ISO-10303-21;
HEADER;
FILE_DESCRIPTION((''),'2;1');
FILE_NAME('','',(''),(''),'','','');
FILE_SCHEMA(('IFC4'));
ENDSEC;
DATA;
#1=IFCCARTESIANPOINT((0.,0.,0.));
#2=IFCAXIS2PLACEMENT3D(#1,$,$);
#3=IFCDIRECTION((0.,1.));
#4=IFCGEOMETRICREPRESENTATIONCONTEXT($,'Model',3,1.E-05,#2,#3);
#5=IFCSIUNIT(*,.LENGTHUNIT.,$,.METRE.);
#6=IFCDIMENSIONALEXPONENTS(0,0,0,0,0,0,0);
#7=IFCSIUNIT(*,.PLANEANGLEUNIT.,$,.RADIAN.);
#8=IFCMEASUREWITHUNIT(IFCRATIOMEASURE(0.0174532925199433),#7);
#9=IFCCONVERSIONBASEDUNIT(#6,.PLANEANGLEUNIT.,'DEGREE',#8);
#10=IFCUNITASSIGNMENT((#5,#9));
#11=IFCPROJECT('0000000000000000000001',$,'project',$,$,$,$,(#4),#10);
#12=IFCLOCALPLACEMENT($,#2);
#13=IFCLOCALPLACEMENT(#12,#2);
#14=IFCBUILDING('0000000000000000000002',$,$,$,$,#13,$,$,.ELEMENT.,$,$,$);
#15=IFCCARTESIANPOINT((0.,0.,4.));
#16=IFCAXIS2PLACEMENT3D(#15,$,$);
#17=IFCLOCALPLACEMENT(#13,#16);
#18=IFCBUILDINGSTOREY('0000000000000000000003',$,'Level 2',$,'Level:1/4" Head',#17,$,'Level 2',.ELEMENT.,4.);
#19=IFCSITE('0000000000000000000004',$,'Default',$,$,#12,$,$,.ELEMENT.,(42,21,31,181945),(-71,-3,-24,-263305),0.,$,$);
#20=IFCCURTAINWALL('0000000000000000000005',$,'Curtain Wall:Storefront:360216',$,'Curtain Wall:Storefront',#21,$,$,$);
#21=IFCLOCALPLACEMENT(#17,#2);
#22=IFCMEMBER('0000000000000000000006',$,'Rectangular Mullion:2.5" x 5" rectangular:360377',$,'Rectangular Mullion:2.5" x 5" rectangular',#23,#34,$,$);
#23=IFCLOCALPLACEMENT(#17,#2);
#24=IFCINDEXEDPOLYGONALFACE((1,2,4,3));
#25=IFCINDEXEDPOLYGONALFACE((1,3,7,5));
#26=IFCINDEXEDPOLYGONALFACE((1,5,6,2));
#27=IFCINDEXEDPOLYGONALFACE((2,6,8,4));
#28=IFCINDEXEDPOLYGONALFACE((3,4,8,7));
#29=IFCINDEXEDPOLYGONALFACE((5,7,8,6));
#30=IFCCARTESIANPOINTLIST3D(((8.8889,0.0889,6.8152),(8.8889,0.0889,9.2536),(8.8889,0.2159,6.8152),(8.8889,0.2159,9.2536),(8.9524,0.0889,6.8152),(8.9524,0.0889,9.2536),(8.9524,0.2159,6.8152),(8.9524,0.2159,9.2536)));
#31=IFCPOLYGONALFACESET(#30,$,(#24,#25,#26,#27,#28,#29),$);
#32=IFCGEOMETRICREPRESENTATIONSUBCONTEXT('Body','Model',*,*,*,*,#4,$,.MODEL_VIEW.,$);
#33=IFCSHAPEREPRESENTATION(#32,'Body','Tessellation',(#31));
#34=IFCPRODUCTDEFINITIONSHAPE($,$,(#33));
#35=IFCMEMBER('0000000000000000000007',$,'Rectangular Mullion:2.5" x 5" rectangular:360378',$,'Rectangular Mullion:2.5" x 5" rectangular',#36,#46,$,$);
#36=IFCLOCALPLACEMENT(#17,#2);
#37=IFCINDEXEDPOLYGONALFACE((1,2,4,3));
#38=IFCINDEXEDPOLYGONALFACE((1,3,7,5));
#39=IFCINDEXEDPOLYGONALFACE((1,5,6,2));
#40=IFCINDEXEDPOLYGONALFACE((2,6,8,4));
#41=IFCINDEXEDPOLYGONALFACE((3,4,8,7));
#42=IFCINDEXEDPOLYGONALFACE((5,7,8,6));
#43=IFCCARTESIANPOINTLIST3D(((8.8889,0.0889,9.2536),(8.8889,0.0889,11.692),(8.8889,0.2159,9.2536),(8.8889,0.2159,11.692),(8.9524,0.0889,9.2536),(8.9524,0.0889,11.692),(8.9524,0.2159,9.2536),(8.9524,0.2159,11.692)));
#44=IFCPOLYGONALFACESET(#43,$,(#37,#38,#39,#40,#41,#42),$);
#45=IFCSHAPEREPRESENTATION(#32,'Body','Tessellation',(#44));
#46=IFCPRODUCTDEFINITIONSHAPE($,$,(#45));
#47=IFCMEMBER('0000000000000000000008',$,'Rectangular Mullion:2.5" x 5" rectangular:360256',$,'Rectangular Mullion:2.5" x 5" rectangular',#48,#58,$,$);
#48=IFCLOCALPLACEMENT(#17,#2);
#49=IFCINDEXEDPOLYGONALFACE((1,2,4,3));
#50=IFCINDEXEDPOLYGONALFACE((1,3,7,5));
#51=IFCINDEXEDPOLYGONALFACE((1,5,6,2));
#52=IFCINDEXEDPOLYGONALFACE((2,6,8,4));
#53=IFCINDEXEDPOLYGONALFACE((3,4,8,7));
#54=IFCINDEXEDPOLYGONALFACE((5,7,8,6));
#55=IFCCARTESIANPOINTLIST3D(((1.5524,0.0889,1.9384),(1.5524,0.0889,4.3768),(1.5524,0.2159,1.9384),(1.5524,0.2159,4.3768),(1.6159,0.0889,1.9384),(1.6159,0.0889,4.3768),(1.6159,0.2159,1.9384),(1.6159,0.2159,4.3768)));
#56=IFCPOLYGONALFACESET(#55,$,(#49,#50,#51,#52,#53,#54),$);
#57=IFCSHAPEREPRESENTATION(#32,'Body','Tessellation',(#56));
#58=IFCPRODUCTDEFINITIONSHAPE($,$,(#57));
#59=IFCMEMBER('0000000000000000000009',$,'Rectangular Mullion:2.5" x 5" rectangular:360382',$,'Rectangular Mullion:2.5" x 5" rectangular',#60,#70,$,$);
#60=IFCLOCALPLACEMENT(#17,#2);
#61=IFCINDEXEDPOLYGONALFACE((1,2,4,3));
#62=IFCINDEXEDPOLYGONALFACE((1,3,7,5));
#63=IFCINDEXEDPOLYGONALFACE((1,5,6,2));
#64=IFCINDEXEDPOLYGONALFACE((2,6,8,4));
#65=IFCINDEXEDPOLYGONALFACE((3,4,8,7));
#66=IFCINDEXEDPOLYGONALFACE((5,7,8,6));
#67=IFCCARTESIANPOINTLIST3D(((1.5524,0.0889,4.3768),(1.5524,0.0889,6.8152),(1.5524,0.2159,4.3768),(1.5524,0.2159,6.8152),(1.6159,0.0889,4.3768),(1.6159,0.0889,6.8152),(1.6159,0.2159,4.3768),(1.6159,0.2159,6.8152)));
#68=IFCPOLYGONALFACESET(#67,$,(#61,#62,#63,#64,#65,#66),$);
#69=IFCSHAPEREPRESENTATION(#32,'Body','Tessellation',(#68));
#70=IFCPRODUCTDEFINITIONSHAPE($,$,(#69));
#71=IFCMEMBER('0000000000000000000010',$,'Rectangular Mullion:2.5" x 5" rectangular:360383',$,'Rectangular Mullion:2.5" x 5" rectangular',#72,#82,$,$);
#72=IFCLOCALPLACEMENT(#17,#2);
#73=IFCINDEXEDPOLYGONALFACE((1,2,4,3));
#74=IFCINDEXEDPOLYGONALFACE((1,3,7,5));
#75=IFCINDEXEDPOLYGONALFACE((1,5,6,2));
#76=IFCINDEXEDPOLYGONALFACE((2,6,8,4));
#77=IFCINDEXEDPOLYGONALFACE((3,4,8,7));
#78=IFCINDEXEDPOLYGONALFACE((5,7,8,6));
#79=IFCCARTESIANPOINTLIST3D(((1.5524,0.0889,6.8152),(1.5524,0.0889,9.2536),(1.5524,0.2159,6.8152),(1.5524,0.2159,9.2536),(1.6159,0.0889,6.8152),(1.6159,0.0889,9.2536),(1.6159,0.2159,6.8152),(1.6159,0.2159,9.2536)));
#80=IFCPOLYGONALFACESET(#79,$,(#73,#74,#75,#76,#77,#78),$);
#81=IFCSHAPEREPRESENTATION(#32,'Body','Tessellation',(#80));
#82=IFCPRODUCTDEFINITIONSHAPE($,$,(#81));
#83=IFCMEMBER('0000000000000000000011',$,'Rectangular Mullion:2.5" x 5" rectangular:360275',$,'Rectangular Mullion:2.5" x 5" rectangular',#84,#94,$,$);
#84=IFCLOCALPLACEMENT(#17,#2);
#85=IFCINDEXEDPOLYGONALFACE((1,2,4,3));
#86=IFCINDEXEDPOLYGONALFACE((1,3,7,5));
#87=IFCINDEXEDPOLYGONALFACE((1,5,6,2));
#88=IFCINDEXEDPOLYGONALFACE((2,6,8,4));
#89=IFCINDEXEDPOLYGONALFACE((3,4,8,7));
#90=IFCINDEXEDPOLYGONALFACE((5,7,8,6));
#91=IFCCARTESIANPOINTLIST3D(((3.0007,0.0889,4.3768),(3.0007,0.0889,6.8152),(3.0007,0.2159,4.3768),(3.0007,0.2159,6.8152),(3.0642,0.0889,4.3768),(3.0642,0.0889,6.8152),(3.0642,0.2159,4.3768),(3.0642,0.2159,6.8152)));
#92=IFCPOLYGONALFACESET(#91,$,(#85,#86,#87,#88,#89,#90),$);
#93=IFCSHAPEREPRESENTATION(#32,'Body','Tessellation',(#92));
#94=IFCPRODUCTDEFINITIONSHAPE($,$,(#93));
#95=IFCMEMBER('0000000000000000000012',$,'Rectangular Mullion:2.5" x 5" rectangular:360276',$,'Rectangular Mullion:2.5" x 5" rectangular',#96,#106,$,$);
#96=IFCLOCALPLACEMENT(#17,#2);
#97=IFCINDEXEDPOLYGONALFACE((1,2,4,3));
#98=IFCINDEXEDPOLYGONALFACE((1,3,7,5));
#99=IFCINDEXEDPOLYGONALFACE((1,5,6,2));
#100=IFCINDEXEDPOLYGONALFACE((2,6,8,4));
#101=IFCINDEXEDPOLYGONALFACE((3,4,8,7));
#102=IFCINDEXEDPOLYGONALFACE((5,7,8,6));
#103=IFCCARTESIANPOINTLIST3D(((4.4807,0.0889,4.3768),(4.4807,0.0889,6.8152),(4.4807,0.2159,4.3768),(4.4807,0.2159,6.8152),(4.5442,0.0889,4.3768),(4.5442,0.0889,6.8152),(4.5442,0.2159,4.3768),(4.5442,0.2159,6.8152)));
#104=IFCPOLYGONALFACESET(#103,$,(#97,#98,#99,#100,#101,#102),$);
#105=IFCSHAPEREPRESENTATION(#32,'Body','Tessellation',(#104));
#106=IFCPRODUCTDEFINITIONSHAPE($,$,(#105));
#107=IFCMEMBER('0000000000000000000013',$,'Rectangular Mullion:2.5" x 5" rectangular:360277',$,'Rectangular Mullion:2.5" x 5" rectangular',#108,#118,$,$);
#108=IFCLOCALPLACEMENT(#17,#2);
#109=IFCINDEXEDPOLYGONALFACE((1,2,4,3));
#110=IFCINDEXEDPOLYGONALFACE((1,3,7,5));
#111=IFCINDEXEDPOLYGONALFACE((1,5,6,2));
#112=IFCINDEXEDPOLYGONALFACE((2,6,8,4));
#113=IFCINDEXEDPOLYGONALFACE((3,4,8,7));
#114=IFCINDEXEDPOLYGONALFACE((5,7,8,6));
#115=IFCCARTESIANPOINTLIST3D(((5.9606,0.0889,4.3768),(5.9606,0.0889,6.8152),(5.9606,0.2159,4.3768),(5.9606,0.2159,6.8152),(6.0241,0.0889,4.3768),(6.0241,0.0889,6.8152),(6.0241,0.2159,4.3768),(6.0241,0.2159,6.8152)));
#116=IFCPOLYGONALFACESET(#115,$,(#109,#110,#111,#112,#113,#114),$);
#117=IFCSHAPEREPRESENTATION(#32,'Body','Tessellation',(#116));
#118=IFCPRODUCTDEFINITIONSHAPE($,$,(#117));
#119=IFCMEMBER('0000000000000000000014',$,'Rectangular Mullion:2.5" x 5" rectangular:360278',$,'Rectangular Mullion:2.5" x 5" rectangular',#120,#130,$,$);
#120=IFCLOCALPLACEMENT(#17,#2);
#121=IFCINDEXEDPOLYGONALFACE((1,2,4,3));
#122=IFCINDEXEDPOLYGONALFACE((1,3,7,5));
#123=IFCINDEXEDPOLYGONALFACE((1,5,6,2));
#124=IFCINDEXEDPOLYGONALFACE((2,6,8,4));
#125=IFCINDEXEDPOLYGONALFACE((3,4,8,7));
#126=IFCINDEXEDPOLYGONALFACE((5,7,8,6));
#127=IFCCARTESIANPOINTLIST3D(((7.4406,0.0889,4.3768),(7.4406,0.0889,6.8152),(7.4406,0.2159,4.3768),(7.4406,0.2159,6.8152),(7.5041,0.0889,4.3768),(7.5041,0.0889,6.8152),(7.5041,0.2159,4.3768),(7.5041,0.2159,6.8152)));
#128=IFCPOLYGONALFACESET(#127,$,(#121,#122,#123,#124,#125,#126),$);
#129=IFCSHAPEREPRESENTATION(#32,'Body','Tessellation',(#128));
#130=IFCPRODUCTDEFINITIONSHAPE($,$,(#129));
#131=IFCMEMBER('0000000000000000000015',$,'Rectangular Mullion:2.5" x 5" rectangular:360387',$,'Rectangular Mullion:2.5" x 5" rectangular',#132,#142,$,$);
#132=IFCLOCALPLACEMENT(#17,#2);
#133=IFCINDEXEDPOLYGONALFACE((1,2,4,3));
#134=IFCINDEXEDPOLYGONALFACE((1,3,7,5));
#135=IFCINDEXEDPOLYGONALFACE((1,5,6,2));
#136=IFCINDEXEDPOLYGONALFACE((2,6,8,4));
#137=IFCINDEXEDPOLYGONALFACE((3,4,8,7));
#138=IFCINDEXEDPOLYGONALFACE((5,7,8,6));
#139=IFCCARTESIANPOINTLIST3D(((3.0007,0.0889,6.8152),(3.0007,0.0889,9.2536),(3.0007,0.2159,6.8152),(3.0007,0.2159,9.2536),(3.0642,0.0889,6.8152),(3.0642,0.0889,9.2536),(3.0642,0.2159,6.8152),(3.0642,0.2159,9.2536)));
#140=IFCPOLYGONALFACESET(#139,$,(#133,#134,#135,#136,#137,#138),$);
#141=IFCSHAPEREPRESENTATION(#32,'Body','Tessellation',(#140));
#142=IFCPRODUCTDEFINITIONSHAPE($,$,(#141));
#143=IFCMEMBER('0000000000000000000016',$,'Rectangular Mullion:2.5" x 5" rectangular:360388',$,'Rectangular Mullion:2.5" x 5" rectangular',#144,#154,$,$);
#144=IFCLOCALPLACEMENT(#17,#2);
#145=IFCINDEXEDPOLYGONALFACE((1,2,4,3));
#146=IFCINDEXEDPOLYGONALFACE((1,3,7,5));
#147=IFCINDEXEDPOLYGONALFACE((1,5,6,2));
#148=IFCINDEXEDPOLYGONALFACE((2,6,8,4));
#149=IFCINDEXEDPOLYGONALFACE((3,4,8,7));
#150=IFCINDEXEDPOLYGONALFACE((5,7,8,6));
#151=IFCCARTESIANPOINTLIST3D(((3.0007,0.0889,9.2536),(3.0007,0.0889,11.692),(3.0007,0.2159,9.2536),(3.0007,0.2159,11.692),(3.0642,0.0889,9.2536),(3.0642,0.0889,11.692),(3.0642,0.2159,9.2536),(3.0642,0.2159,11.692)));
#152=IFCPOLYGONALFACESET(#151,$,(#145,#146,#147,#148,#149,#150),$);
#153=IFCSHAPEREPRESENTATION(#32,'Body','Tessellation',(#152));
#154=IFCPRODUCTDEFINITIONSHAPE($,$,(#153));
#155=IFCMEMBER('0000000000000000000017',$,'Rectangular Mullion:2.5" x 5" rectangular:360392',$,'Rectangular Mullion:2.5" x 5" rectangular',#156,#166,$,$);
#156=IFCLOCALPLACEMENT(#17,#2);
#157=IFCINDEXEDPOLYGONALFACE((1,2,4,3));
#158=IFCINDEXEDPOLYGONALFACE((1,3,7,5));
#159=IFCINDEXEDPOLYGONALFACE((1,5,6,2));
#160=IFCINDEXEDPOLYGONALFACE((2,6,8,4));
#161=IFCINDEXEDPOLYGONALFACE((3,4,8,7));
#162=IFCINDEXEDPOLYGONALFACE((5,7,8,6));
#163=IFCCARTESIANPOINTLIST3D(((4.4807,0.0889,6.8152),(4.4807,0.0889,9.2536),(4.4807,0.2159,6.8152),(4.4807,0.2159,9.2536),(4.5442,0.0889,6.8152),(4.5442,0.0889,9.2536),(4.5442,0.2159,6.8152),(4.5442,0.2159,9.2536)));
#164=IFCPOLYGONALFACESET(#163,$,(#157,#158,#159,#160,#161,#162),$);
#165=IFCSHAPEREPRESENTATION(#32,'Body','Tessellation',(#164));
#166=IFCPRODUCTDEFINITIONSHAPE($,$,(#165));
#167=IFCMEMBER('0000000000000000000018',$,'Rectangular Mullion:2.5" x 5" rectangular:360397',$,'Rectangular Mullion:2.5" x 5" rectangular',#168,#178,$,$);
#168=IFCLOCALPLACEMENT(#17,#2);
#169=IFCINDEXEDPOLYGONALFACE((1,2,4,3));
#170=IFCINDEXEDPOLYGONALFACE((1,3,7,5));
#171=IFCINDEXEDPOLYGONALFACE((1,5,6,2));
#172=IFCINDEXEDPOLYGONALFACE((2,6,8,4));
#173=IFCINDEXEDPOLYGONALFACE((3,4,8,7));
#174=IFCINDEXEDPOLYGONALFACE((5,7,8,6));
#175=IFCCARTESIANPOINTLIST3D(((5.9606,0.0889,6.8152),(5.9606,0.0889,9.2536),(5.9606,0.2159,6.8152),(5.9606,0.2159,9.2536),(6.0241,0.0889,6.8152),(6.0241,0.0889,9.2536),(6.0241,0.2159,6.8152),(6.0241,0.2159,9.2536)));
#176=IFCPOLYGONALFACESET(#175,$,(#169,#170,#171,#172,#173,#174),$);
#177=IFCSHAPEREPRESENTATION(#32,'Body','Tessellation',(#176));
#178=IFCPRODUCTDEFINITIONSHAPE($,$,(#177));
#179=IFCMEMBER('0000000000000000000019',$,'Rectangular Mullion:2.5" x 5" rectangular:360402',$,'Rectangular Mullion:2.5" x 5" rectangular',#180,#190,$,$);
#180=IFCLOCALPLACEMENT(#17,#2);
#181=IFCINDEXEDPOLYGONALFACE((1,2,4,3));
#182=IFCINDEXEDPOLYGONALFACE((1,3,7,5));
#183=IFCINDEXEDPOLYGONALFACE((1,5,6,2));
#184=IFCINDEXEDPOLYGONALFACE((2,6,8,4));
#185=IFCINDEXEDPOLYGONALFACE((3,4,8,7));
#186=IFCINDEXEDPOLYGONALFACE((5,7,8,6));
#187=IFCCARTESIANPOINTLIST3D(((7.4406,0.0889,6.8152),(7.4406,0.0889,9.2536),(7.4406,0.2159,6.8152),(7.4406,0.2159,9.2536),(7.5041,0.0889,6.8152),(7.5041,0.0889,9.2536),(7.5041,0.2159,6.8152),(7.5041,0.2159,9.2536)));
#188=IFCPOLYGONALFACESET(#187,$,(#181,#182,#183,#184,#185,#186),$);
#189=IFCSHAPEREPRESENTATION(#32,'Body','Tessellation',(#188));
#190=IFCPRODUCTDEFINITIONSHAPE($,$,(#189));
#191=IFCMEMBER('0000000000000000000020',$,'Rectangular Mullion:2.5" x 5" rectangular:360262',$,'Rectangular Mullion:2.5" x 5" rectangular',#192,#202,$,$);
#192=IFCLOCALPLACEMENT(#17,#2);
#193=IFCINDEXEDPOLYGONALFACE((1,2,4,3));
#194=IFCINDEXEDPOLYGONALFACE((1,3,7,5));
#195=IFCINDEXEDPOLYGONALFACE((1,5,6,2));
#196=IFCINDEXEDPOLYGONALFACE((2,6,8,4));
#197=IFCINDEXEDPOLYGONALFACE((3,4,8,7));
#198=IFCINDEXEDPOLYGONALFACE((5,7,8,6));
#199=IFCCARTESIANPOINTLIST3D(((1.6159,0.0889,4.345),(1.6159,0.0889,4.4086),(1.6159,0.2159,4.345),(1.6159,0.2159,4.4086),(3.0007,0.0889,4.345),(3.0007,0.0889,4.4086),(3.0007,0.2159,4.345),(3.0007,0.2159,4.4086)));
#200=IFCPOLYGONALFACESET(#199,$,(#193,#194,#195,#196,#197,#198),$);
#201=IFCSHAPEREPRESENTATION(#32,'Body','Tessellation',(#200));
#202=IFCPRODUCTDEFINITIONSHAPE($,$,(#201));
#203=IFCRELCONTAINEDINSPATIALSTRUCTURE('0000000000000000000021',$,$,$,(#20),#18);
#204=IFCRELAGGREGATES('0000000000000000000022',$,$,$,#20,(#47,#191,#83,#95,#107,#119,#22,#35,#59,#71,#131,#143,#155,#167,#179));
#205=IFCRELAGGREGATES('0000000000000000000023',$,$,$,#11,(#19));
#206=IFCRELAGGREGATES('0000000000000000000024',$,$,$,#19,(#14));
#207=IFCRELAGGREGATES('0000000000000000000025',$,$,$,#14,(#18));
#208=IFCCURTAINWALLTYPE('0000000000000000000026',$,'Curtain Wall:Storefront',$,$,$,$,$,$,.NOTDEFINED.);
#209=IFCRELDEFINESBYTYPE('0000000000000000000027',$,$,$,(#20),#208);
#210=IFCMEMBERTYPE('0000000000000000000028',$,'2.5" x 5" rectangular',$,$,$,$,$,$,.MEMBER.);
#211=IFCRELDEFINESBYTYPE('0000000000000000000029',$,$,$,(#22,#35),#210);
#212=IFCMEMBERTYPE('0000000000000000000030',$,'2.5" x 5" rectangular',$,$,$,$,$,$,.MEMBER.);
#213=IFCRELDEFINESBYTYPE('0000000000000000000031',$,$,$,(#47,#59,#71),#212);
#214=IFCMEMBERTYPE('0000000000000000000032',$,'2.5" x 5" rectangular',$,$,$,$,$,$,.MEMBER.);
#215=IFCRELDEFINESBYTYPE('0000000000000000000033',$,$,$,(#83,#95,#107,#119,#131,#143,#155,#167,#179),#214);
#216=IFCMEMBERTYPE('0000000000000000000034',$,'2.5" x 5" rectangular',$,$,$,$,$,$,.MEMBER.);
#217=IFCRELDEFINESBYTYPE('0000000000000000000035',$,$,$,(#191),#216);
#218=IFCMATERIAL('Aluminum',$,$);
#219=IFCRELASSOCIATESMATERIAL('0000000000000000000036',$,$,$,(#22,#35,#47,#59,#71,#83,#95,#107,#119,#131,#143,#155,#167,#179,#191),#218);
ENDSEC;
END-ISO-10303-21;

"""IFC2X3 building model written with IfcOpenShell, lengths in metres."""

from ifc_helpers import new_model, entity, si_unit, converted_unit, direction, frame, origin, origin_2d_with_axis, place, context, subcontext, project, spatial, rectangle, extrude, source, transform, mapped, material, type_object, type_shapes, element, aggregate, save


model = new_model("IFC2X3")

# Units and contexts
model_context = context("Model", 3, precision=1e-05, world=origin(), true_north=direction((0.0, 1.0)))
body_context = subcontext(model_context, "Body", "Model", "MODEL_VIEW")
ifc_project = project(units=[si_unit("LENGTHUNIT", "METRE"), converted_unit("PLANEANGLEUNIT", "DEGREE", entity("IfcRatioMeasure", 0.0174532925199433), si_unit("PLANEANGLEUNIT", "RADIAN"), dimensions=[0, 0, 0, 0, 0, 0, 0])], contexts=[model_context])

# Site, building, storey
site_placement = place(None, origin())
site = spatial("IfcSite", under=ifc_project, at=site_placement, Name="Default", CompositionType="ELEMENT", RefLatitude=(42, 21, 31, 181945), RefLongitude=(-71, -3, -24, -263305), RefElevation=0.0)
building_placement = place(site_placement, origin())
building = spatial("IfcBuilding", under=site, at=building_placement, CompositionType="ELEMENT")
storey_placement = place(building_placement, frame((0.0, 0.0, 4.0)))
storey = spatial("IfcBuildingStorey", under=building, at=storey_placement, Name="Level 2", ObjectType="Level:1/4\" Head", LongName="Level 2", CompositionType="ELEMENT", Elevation=4.0)

# Curtain wall, members
curtain_wall_type = type_object("IfcCurtainWallType", Name="Curtain Wall:Storefront", PredefinedType="NOTDEFINED")
curtain_wall_placement = place(storey_placement, frame((0.0, 0.0, -4.0)))
curtain_wall = element("IfcCurtainWall", 1, at=curtain_wall_placement, inside=storey, type_object=curtain_wall_type, Name="Curtain Wall:Storefront:360216", ObjectType="Curtain Wall:Storefront")
ifc_material_1 = material(Name="Aluminum")
member_type_1 = type_object("IfcMemberType", Name="2.5\" x 5\" rectangular", PredefinedType="MEMBER")
shared_shape_1 = source(origin(), body_context, "Body", "SweptSolid", [
    extrude(rectangle(XDim=0.127, YDim=0.0635, at=origin_2d_with_axis()), frame((-0.0318, 0.0, -2.4384), z_axis=(0.0, 0.0, 1.0), x_axis=(0.0, -1.0, 0.0)), (0.0, 0.0, 1.0), 2.4384),
])
type_shapes(member_type_1, [shared_shape_1])
member_1_placement = place(storey_placement, frame((8.9524, 0.1524, 6.8152), z_axis=(0.0, 0.0, -1.0), x_axis=(1.0, 0.0, 0.0)))
member_1 = element("IfcMember", 2, at=member_1_placement, type_object=member_type_1, material=ifc_material_1, Name="Rectangular Mullion:2.5\" x 5\" rectangular:360377", ObjectType="Rectangular Mullion:2.5\" x 5\" rectangular", context=body_context, shape_type="MappedRepresentation", body=[
    mapped(shared_shape_1, transform((0.0, 0.0, 0.0), scale=1.0)),
])
member_2_placement = place(storey_placement, frame((8.9524, 0.1524, 9.2536), z_axis=(0.0, 0.0, -1.0), x_axis=(1.0, 0.0, 0.0)))
member_2 = element("IfcMember", 3, at=member_2_placement, type_object=member_type_1, material=ifc_material_1, Name="Rectangular Mullion:2.5\" x 5\" rectangular:360378", ObjectType="Rectangular Mullion:2.5\" x 5\" rectangular", context=body_context, shape_type="MappedRepresentation", body=[
    mapped(shared_shape_1, transform((0.0, 0.0, 0.0), scale=1.0)),
])
member_type_2 = type_object("IfcMemberType", Name="2.5\" x 5\" rectangular", PredefinedType="MEMBER")
shared_shape_2 = source(origin(), body_context, "Body", "SweptSolid", [
    extrude(rectangle(XDim=0.127, YDim=0.0635, at=origin_2d_with_axis()), frame((-0.0318, 0.0, -2.4384), z_axis=(0.0, 0.0, 1.0), x_axis=(0.0, -1.0, 0.0)), (0.0, 0.0, 1.0), 2.4384),
])
type_shapes(member_type_2, [shared_shape_2])
member_3_placement = place(storey_placement, frame((1.5524, 0.1524, 4.3768), z_axis=(0.0, 0.0, 1.0), x_axis=(-1.0, 0.0, 0.0)))
member_3 = element("IfcMember", 4, at=member_3_placement, type_object=member_type_2, material=ifc_material_1, Name="Rectangular Mullion:2.5\" x 5\" rectangular:360256", ObjectType="Rectangular Mullion:2.5\" x 5\" rectangular", context=body_context, shape_type="MappedRepresentation", body=[
    mapped(shared_shape_2, transform((0.0, 0.0, 0.0), scale=1.0)),
])
member_4_placement = place(storey_placement, frame((1.5524, 0.1524, 6.8152), z_axis=(0.0, 0.0, 1.0), x_axis=(-1.0, 0.0, 0.0)))
member_4 = element("IfcMember", 5, at=member_4_placement, type_object=member_type_2, material=ifc_material_1, Name="Rectangular Mullion:2.5\" x 5\" rectangular:360382", ObjectType="Rectangular Mullion:2.5\" x 5\" rectangular", context=body_context, shape_type="MappedRepresentation", body=[
    mapped(shared_shape_2, transform((0.0, 0.0, 0.0), scale=1.0)),
])
member_5_placement = place(storey_placement, frame((1.5524, 0.1524, 9.2536), z_axis=(0.0, 0.0, 1.0), x_axis=(-1.0, 0.0, 0.0)))
member_5 = element("IfcMember", 6, at=member_5_placement, type_object=member_type_2, material=ifc_material_1, Name="Rectangular Mullion:2.5\" x 5\" rectangular:360383", ObjectType="Rectangular Mullion:2.5\" x 5\" rectangular", context=body_context, shape_type="MappedRepresentation", body=[
    mapped(shared_shape_2, transform((0.0, 0.0, 0.0), scale=1.0)),
])
member_type_3 = type_object("IfcMemberType", Name="2.5\" x 5\" rectangular", PredefinedType="MEMBER")
shared_shape_3 = source(origin(), body_context, "Body", "SweptSolid", [
    extrude(rectangle(XDim=0.127, YDim=0.0635, at=origin_2d_with_axis()), frame((0.0, 0.0, -2.4384), z_axis=(0.0, 0.0, 1.0), x_axis=(0.0, -1.0, 0.0)), (0.0, 0.0, 1.0), 2.4384),
])
type_shapes(member_type_3, [shared_shape_3])
member_6_placement = place(storey_placement, frame((3.0324, 0.1524, 4.3768), z_axis=(0.0, 0.0, -1.0), x_axis=(1.0, 0.0, 0.0)))
member_6 = element("IfcMember", 7, at=member_6_placement, type_object=member_type_3, material=ifc_material_1, Name="Rectangular Mullion:2.5\" x 5\" rectangular:360275", ObjectType="Rectangular Mullion:2.5\" x 5\" rectangular", context=body_context, shape_type="MappedRepresentation", body=[
    mapped(shared_shape_3, transform((0.0, 0.0, 0.0), scale=1.0)),
])
member_7_placement = place(storey_placement, frame((4.5124, 0.1524, 4.3768), z_axis=(0.0, 0.0, -1.0), x_axis=(1.0, 0.0, 0.0)))
member_7 = element("IfcMember", 8, at=member_7_placement, type_object=member_type_3, material=ifc_material_1, Name="Rectangular Mullion:2.5\" x 5\" rectangular:360276", ObjectType="Rectangular Mullion:2.5\" x 5\" rectangular", context=body_context, shape_type="MappedRepresentation", body=[
    mapped(shared_shape_3, transform((0.0, 0.0, 0.0), scale=1.0)),
])
member_8_placement = place(storey_placement, frame((5.9924, 0.1524, 4.3768), z_axis=(0.0, 0.0, -1.0), x_axis=(1.0, 0.0, 0.0)))
member_8 = element("IfcMember", 9, at=member_8_placement, type_object=member_type_3, material=ifc_material_1, Name="Rectangular Mullion:2.5\" x 5\" rectangular:360277", ObjectType="Rectangular Mullion:2.5\" x 5\" rectangular", context=body_context, shape_type="MappedRepresentation", body=[
    mapped(shared_shape_3, transform((0.0, 0.0, 0.0), scale=1.0)),
])
member_9_placement = place(storey_placement, frame((7.4724, 0.1524, 4.3768), z_axis=(0.0, 0.0, -1.0), x_axis=(1.0, 0.0, 0.0)))
member_9 = element("IfcMember", 10, at=member_9_placement, type_object=member_type_3, material=ifc_material_1, Name="Rectangular Mullion:2.5\" x 5\" rectangular:360278", ObjectType="Rectangular Mullion:2.5\" x 5\" rectangular", context=body_context, shape_type="MappedRepresentation", body=[
    mapped(shared_shape_3, transform((0.0, 0.0, 0.0), scale=1.0)),
])
member_10_placement = place(storey_placement, frame((3.0324, 0.1524, 6.8152), z_axis=(0.0, 0.0, -1.0), x_axis=(1.0, 0.0, 0.0)))
member_10 = element("IfcMember", 11, at=member_10_placement, type_object=member_type_3, material=ifc_material_1, Name="Rectangular Mullion:2.5\" x 5\" rectangular:360387", ObjectType="Rectangular Mullion:2.5\" x 5\" rectangular", context=body_context, shape_type="MappedRepresentation", body=[
    mapped(shared_shape_3, transform((0.0, 0.0, 0.0), scale=1.0)),
])
member_11_placement = place(storey_placement, frame((3.0324, 0.1524, 9.2536), z_axis=(0.0, 0.0, -1.0), x_axis=(1.0, 0.0, 0.0)))
member_11 = element("IfcMember", 12, at=member_11_placement, type_object=member_type_3, material=ifc_material_1, Name="Rectangular Mullion:2.5\" x 5\" rectangular:360388", ObjectType="Rectangular Mullion:2.5\" x 5\" rectangular", context=body_context, shape_type="MappedRepresentation", body=[
    mapped(shared_shape_3, transform((0.0, 0.0, 0.0), scale=1.0)),
])
member_12_placement = place(storey_placement, frame((4.5124, 0.1524, 6.8152), z_axis=(0.0, 0.0, -1.0), x_axis=(1.0, 0.0, 0.0)))
member_12 = element("IfcMember", 13, at=member_12_placement, type_object=member_type_3, material=ifc_material_1, Name="Rectangular Mullion:2.5\" x 5\" rectangular:360392", ObjectType="Rectangular Mullion:2.5\" x 5\" rectangular", context=body_context, shape_type="MappedRepresentation", body=[
    mapped(shared_shape_3, transform((0.0, 0.0, 0.0), scale=1.0)),
])
member_13_placement = place(storey_placement, frame((5.9924, 0.1524, 6.8152), z_axis=(0.0, 0.0, -1.0), x_axis=(1.0, 0.0, 0.0)))
member_13 = element("IfcMember", 14, at=member_13_placement, type_object=member_type_3, material=ifc_material_1, Name="Rectangular Mullion:2.5\" x 5\" rectangular:360397", ObjectType="Rectangular Mullion:2.5\" x 5\" rectangular", context=body_context, shape_type="MappedRepresentation", body=[
    mapped(shared_shape_3, transform((0.0, 0.0, 0.0), scale=1.0)),
])
member_14_placement = place(storey_placement, frame((7.4724, 0.1524, 6.8152), z_axis=(0.0, 0.0, -1.0), x_axis=(1.0, 0.0, 0.0)))
member_14 = element("IfcMember", 15, at=member_14_placement, type_object=member_type_3, material=ifc_material_1, Name="Rectangular Mullion:2.5\" x 5\" rectangular:360402", ObjectType="Rectangular Mullion:2.5\" x 5\" rectangular", context=body_context, shape_type="MappedRepresentation", body=[
    mapped(shared_shape_3, transform((0.0, 0.0, 0.0), scale=1.0)),
])
member_type_4 = type_object("IfcMemberType", Name="2.5\" x 5\" rectangular", PredefinedType="MEMBER")
shared_shape_4 = source(origin(), body_context, "Body", "SweptSolid", [
    extrude(rectangle(XDim=0.127, YDim=0.0635, at=origin_2d_with_axis()), frame((0.0, 0.0, -1.3848), z_axis=(0.0, 0.0, 1.0), x_axis=(0.0, -1.0, 0.0)), (0.0, 0.0, 1.0), 1.3848),
])
type_shapes(member_type_4, [shared_shape_4])
member_15_placement = place(storey_placement, frame((3.0007, 0.1524, 4.3768), z_axis=(1.0, 0.0, 0.0), x_axis=(0.0, 0.0, 1.0)))
member_15 = element("IfcMember", 16, at=member_15_placement, type_object=member_type_4, material=ifc_material_1, Name="Rectangular Mullion:2.5\" x 5\" rectangular:360262", ObjectType="Rectangular Mullion:2.5\" x 5\" rectangular", context=body_context, shape_type="MappedRepresentation", body=[
    mapped(shared_shape_4, transform((0.0, 0.0, 0.0), scale=1.0)),
])
aggregate(curtain_wall, [member_3, member_15, member_6, member_7, member_8, member_9, member_1, member_2, member_4, member_5, member_10, member_11, member_12, member_13, member_14])

save(model, "model.ifc")
